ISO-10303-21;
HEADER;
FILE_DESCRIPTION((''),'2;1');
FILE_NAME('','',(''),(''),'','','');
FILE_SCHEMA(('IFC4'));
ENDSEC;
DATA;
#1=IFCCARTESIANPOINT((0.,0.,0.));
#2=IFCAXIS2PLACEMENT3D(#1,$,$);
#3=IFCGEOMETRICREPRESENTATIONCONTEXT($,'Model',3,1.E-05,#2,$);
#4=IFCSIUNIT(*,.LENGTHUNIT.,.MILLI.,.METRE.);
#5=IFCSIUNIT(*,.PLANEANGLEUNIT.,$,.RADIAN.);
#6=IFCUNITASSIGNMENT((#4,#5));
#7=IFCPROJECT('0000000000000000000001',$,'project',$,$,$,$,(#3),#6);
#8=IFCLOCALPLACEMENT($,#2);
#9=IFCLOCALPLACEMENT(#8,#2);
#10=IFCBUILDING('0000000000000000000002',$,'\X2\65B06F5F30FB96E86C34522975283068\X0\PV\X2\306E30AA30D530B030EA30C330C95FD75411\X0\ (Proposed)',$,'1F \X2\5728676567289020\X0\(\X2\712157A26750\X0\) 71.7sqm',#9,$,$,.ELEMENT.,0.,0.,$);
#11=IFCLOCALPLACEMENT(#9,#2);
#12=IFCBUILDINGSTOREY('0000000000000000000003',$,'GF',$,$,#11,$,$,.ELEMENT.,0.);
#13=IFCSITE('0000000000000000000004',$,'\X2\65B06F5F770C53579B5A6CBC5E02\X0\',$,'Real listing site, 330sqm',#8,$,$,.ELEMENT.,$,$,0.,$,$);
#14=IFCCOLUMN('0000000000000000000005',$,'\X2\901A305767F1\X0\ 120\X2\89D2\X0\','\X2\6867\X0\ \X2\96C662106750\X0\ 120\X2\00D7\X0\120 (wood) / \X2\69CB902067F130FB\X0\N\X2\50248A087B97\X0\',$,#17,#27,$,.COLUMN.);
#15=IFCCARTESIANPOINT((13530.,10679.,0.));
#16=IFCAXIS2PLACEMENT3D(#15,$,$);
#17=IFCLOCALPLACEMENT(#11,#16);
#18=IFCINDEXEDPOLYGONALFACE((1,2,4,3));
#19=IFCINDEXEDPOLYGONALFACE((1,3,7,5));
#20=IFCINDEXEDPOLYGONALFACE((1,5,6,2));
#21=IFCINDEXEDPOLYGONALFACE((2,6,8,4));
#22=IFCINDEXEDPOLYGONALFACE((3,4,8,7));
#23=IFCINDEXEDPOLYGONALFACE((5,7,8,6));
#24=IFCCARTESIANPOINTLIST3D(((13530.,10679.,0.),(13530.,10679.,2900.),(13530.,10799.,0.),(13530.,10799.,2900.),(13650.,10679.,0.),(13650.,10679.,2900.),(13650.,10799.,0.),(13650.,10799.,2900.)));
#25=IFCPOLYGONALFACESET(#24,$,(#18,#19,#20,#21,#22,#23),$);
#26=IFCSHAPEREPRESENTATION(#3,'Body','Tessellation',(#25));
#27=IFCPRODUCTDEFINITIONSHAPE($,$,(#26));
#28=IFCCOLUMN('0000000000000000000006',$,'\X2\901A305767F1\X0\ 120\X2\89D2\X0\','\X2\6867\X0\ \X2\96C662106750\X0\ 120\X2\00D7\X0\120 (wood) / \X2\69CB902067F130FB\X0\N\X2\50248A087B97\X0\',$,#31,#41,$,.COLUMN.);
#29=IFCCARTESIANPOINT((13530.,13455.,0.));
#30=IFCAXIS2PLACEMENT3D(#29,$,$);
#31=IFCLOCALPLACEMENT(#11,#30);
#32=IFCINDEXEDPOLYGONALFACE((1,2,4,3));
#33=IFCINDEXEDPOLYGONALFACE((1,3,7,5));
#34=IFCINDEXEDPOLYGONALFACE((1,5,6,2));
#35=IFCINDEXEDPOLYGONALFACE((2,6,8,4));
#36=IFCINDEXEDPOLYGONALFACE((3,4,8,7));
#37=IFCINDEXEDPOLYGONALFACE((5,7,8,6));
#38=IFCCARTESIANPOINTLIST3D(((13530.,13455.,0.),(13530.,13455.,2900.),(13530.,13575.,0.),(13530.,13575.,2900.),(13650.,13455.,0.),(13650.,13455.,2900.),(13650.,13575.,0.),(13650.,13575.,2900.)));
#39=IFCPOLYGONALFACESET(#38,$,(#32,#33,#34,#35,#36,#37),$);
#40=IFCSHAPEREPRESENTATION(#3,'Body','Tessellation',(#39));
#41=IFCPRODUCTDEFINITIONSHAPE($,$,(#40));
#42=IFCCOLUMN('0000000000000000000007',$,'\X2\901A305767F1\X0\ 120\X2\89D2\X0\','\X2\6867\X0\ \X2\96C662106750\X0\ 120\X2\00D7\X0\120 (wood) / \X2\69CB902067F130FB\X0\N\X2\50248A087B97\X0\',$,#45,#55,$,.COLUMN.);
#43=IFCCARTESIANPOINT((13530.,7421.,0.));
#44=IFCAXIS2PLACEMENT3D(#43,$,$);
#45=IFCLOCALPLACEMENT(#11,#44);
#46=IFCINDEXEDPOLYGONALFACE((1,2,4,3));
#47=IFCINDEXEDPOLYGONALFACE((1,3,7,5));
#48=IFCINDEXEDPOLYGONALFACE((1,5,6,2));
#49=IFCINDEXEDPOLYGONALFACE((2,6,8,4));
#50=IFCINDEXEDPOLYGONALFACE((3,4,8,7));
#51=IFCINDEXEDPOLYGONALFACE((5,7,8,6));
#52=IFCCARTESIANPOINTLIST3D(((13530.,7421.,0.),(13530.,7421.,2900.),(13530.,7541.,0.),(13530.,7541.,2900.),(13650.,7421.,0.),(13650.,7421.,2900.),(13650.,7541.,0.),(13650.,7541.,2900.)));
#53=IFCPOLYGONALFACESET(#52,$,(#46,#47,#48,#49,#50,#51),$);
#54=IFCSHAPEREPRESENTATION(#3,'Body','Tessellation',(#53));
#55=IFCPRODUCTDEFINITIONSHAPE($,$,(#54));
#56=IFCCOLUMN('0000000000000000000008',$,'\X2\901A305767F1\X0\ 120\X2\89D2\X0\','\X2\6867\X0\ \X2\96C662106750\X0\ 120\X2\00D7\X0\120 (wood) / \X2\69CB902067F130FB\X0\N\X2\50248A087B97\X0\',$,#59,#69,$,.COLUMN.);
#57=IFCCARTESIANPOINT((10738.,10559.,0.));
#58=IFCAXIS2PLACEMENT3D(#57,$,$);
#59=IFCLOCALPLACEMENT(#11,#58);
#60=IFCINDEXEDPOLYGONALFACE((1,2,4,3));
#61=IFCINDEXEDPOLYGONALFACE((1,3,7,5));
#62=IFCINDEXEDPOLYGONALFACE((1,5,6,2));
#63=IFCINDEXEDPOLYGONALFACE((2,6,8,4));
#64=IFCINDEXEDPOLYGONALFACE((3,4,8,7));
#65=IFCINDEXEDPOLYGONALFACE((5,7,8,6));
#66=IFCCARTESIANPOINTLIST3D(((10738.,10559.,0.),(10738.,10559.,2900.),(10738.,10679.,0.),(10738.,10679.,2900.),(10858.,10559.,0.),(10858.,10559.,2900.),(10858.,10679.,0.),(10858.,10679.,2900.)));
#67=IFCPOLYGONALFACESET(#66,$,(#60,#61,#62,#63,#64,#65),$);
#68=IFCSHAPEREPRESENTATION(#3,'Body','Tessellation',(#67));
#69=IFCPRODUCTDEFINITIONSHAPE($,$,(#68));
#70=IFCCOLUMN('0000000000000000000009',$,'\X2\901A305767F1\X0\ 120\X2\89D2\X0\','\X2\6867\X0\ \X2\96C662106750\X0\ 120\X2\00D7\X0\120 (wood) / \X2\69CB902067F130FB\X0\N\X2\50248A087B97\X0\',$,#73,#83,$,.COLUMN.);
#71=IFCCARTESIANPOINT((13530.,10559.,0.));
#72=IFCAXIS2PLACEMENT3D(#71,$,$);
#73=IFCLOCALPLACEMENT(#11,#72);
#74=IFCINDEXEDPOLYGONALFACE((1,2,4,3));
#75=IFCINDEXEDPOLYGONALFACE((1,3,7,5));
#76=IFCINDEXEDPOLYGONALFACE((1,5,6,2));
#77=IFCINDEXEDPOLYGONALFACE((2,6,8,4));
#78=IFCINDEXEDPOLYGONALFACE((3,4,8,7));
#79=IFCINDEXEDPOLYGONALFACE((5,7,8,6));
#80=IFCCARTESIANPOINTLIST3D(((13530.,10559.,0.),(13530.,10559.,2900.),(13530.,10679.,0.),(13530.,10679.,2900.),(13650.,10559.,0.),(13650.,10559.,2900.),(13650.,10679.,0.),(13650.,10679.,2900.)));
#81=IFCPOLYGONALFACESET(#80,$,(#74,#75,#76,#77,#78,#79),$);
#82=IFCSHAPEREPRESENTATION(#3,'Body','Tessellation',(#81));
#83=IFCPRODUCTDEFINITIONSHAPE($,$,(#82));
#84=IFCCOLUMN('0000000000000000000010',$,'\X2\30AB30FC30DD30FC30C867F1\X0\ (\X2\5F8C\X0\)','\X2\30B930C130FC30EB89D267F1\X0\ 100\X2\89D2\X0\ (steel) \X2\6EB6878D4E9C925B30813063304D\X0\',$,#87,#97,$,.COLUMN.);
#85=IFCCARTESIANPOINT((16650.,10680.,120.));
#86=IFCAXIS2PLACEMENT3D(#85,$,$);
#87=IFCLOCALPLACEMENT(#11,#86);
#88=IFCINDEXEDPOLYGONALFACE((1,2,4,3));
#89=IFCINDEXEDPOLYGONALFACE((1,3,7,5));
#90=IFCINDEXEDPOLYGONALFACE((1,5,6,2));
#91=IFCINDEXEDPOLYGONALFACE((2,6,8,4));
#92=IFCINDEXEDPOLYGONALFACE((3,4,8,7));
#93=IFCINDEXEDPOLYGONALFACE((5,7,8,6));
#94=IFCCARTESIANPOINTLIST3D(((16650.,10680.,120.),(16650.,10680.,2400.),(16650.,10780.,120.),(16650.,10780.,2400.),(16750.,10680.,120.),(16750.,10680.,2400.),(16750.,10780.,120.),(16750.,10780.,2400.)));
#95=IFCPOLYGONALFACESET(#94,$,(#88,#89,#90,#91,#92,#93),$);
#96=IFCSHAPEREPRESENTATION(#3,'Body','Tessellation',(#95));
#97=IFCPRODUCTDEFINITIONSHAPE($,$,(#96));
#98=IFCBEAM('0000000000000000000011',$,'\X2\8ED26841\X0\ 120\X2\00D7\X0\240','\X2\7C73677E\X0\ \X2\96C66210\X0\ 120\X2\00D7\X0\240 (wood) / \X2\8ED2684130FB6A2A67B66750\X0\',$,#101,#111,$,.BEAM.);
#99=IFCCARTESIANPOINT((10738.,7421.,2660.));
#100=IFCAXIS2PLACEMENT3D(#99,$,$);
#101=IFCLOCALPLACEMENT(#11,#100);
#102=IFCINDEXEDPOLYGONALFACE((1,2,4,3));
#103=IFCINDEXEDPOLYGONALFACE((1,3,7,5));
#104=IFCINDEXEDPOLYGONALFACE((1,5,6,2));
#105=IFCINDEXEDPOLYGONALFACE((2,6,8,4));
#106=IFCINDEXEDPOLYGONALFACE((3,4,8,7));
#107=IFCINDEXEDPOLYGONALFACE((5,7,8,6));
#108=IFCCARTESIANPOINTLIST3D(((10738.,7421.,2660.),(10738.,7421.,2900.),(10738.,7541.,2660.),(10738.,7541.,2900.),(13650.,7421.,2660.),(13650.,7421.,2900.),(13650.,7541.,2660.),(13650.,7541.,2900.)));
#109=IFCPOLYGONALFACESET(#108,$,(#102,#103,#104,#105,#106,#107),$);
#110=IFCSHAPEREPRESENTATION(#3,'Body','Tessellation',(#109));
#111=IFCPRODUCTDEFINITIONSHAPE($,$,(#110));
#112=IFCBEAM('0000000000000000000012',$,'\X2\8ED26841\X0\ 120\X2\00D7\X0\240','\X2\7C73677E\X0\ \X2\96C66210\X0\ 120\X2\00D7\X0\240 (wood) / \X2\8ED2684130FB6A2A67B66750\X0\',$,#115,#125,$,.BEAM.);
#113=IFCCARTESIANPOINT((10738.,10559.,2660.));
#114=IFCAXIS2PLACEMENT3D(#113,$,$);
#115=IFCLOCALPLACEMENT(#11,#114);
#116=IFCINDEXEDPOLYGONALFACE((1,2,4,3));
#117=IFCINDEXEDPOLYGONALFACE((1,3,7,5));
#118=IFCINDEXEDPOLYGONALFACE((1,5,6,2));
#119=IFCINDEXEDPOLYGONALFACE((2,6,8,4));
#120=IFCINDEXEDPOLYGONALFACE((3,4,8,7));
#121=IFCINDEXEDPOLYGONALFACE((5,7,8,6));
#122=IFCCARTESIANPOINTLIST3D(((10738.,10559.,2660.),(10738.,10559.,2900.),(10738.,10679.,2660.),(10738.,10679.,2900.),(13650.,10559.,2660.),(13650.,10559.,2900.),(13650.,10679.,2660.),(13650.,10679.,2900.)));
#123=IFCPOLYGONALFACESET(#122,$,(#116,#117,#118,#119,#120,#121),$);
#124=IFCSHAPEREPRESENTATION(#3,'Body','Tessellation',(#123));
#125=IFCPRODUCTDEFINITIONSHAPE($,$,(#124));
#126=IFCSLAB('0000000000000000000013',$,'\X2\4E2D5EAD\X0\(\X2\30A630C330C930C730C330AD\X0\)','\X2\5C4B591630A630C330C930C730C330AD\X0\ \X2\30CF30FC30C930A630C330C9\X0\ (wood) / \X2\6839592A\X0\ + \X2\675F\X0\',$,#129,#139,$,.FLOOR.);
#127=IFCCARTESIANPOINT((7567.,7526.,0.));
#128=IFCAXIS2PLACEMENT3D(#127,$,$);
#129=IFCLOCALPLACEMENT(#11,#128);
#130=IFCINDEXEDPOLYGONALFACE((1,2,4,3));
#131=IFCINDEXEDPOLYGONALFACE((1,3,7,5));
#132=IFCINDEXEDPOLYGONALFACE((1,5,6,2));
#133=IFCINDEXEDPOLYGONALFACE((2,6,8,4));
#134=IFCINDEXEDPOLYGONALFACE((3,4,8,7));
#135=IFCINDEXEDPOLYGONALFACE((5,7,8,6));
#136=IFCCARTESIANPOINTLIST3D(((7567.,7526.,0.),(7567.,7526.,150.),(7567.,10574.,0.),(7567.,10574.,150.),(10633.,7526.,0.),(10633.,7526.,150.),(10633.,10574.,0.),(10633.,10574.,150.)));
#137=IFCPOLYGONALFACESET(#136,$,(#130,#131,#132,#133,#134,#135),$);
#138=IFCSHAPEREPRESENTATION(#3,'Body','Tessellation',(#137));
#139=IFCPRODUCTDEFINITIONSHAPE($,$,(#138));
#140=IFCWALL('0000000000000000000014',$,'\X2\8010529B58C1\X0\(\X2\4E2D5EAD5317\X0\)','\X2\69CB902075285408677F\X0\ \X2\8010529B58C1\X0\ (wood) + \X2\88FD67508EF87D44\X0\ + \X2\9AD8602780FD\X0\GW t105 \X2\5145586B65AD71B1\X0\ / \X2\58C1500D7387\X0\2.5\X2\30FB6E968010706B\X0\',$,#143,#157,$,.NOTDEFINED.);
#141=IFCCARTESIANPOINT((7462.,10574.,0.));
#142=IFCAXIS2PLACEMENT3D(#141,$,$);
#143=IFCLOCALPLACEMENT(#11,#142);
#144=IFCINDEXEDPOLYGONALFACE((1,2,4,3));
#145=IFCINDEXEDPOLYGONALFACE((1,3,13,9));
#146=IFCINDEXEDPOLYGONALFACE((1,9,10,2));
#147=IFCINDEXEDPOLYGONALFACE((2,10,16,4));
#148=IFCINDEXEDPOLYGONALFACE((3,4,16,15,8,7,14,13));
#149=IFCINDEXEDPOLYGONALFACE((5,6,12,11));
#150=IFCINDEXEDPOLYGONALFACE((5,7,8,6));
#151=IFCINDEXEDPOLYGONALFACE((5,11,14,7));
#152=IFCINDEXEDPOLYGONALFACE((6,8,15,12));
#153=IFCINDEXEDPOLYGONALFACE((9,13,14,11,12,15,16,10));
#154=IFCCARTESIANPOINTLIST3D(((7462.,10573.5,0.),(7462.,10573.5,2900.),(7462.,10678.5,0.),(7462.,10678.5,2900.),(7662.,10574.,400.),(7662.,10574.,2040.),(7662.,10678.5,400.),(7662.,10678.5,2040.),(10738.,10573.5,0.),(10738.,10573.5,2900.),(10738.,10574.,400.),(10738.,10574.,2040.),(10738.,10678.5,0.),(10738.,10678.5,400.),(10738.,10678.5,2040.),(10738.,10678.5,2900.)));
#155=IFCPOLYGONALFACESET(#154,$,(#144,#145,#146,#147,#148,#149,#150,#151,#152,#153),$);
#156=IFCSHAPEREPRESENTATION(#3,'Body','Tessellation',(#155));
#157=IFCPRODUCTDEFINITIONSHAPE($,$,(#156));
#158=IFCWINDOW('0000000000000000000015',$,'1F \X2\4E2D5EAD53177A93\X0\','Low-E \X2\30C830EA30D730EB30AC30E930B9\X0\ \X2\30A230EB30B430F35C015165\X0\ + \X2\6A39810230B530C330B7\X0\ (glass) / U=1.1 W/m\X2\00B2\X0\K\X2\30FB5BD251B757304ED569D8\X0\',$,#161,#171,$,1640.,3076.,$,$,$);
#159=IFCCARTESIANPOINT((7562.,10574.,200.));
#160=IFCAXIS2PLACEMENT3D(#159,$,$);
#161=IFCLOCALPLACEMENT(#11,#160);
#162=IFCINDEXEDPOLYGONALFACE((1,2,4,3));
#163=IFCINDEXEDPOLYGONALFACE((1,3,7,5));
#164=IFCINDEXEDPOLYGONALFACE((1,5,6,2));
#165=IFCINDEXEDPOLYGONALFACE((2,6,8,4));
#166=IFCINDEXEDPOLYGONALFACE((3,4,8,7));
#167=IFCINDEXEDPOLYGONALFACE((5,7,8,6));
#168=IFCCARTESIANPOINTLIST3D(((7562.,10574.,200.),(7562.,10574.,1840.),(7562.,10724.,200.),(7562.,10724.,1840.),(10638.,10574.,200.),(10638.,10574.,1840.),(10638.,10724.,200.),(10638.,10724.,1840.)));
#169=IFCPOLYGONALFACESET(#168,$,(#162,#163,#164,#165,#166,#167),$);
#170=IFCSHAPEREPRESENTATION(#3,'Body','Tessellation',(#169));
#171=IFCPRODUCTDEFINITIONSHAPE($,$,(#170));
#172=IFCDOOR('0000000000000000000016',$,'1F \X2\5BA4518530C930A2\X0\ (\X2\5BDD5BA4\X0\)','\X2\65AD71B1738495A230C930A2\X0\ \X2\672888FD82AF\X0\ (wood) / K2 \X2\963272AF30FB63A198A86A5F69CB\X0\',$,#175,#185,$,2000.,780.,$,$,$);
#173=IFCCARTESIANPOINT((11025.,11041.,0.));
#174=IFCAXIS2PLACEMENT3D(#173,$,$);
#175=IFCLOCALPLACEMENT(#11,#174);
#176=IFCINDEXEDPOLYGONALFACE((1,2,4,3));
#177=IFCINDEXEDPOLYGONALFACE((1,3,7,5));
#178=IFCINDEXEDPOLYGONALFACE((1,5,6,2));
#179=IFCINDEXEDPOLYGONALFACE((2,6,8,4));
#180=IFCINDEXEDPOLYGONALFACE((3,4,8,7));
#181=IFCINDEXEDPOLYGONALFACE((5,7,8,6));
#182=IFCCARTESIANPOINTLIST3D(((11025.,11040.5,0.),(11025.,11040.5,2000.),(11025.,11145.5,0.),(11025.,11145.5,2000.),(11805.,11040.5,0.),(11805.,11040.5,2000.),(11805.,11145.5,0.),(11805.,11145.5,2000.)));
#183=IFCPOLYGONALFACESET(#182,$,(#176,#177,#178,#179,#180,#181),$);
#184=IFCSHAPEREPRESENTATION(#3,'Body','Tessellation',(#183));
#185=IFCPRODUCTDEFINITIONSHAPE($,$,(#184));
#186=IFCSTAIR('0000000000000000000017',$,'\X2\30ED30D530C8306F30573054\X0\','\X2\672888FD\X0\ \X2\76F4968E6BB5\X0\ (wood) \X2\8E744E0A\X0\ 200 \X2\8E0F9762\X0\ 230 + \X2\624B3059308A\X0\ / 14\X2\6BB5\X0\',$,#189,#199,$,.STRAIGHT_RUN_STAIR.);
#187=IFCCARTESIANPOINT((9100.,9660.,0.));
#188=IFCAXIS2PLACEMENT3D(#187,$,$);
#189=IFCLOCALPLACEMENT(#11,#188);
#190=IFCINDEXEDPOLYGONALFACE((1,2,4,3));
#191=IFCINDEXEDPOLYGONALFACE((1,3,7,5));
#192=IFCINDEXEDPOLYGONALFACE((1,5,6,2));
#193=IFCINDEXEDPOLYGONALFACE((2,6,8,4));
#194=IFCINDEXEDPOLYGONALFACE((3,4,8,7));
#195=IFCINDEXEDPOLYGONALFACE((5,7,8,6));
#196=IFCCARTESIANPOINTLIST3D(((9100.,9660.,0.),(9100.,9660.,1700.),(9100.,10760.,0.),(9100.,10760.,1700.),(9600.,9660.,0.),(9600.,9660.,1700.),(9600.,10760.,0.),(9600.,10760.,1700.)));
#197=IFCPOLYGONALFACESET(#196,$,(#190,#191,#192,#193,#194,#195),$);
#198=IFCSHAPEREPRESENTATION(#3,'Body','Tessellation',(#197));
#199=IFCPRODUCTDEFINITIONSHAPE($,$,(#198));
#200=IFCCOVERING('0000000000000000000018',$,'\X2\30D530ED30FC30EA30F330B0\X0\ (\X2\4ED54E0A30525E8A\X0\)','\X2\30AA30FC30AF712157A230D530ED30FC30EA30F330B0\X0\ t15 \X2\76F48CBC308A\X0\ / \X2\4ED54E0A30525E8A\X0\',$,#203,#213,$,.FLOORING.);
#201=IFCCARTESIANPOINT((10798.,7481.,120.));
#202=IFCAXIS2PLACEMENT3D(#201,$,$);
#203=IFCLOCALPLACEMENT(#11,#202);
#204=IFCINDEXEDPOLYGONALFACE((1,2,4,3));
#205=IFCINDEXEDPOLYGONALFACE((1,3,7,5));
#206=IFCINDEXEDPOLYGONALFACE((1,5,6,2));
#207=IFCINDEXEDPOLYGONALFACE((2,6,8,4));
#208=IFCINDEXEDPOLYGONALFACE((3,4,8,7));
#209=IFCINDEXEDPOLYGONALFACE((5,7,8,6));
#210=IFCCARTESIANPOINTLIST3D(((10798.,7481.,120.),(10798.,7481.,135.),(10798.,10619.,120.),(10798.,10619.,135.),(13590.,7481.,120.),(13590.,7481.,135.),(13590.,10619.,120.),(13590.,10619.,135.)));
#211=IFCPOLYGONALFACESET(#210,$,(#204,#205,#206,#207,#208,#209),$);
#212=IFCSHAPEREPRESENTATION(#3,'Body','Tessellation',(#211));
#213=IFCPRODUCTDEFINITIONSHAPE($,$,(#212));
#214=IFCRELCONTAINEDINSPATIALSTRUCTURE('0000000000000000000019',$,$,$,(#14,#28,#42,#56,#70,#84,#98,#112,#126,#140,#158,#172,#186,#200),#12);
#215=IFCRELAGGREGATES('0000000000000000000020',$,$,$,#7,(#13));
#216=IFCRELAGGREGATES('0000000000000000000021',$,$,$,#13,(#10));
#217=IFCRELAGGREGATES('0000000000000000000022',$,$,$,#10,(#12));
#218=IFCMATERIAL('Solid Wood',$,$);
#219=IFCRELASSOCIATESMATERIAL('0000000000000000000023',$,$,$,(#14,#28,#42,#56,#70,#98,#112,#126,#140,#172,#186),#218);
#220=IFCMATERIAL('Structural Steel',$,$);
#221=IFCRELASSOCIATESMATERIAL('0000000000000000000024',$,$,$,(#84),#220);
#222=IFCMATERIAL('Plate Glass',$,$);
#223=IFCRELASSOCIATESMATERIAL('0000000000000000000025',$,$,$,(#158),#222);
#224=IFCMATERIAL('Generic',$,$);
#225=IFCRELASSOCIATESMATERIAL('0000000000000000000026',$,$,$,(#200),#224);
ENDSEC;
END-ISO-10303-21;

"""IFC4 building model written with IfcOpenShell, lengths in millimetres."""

from ifc_helpers import new_model, si_unit, frame, frame_2d, origin, place, context, project, spatial, rectangle, extrude, material, element, fill, save


model = new_model("IFC4")

# Units and contexts
model_context = context("Model", 3, precision=1e-05, world=origin())
ifc_project = project(units=[si_unit("LENGTHUNIT", "METRE", prefix="MILLI"), si_unit("PLANEANGLEUNIT", "RADIAN")], contexts=[model_context])

# Site, building, storey
site_placement = place(None, origin())
site = spatial("IfcSite", under=ifc_project, at=site_placement, Name="新潟県南魚沼市", ObjectType="Real listing site, 330sqm", CompositionType="ELEMENT", RefElevation=0.0)
building_placement = place(site_placement, origin())
building = spatial("IfcBuilding", under=site, at=building_placement, Name="新潟・雨水利用とPVのオフグリッド志向 (Proposed)", ObjectType="1F 在来木造(無垢材) 71.7sqm", CompositionType="ELEMENT", ElevationOfRefHeight=0.0, ElevationOfTerrain=0.0)
storey_placement = place(building_placement, origin())
storey = spatial("IfcBuildingStorey", under=building, at=storey_placement, Name="GF", CompositionType="ELEMENT", Elevation=0.0)

# Columns
ifc_material_1 = material(Name="Solid Wood")
column_1_placement = place(storey_placement, frame((13530.0, 10679.0, 0.0)))
element("IfcColumn", 1, at=column_1_placement, inside=storey, material=ifc_material_1, Name="通し柱 120角", Description="桧 集成材 120×120 (wood) / 構造柱・N値計算", PredefinedType="COLUMN", context=model_context, shape_type="SweptSolid", body=[
    extrude(rectangle(XDim=120.0, YDim=120.0, at=frame_2d((60.0, 60.0))), frame((13530.0, 10679.0, 0.0)), (0.0, 0.0, 1.0), 2900.0),
])
column_2_placement = place(storey_placement, frame((13530.0, 13455.0, 0.0)))
element("IfcColumn", 2, at=column_2_placement, inside=storey, material=ifc_material_1, Name="通し柱 120角", Description="桧 集成材 120×120 (wood) / 構造柱・N値計算", PredefinedType="COLUMN", context=model_context, shape_type="SweptSolid", body=[
    extrude(rectangle(XDim=120.0, YDim=120.0, at=frame_2d((60.0, 60.0))), frame((13530.0, 13455.0, 0.0)), (0.0, 0.0, 1.0), 2900.0),
])
column_3_placement = place(storey_placement, frame((13530.0, 7421.0, 0.0)))
element("IfcColumn", 3, at=column_3_placement, inside=storey, material=ifc_material_1, Name="通し柱 120角", Description="桧 集成材 120×120 (wood) / 構造柱・N値計算", PredefinedType="COLUMN", context=model_context, shape_type="SweptSolid", body=[
    extrude(rectangle(XDim=120.0, YDim=120.0, at=frame_2d((60.0, 60.0))), frame((13530.0, 7421.0, 0.0)), (0.0, 0.0, 1.0), 2900.0),
])
column_4_placement = place(storey_placement, frame((10738.0, 10559.0, 0.0)))
element("IfcColumn", 4, at=column_4_placement, inside=storey, material=ifc_material_1, Name="通し柱 120角", Description="桧 集成材 120×120 (wood) / 構造柱・N値計算", PredefinedType="COLUMN", context=model_context, shape_type="SweptSolid", body=[
    extrude(rectangle(XDim=120.0, YDim=120.0, at=frame_2d((60.0, 60.0))), frame((10738.0, 10559.0, 0.0)), (0.0, 0.0, 1.0), 2900.0),
])
column_5_placement = place(storey_placement, frame((13530.0, 10559.0, 0.0)))
element("IfcColumn", 5, at=column_5_placement, inside=storey, material=ifc_material_1, Name="通し柱 120角", Description="桧 集成材 120×120 (wood) / 構造柱・N値計算", PredefinedType="COLUMN", context=model_context, shape_type="SweptSolid", body=[
    extrude(rectangle(XDim=120.0, YDim=120.0, at=frame_2d((60.0, 60.0))), frame((13530.0, 10559.0, 0.0)), (0.0, 0.0, 1.0), 2900.0),
])
ifc_material_2 = material(Name="Structural Steel")
column_6_placement = place(storey_placement, frame((16650.0, 10680.0, 120.0)))
element("IfcColumn", 6, at=column_6_placement, inside=storey, material=ifc_material_2, Name="カーポート柱 (後)", Description="スチール角柱 100角 (steel) 溶融亜鉛めっき", PredefinedType="COLUMN", context=model_context, shape_type="SweptSolid", body=[
    extrude(rectangle(XDim=100.0, YDim=100.0, at=frame_2d((50.0, 50.0))), frame((16650.0, 10680.0, 120.0)), (0.0, 0.0, 1.0), 2280.0),
])

# Beams
beam_1_placement = place(storey_placement, frame((10738.0, 7421.0, 2660.0)))
element("IfcBeam", 7, at=beam_1_placement, inside=storey, material=ifc_material_1, Name="軒桁 120×240", Description="米松 集成 120×240 (wood) / 軒桁・横架材", PredefinedType="BEAM", context=model_context, shape_type="SweptSolid", body=[
    extrude(rectangle(XDim=2912.0, YDim=120.0, at=frame_2d((1456.0, 60.0))), frame((10738.0, 7421.0, 2660.0)), (0.0, 0.0, 1.0), 240.0),
])
beam_2_placement = place(storey_placement, frame((10738.0, 10559.0, 2660.0)))
element("IfcBeam", 8, at=beam_2_placement, inside=storey, material=ifc_material_1, Name="軒桁 120×240", Description="米松 集成 120×240 (wood) / 軒桁・横架材", PredefinedType="BEAM", context=model_context, shape_type="SweptSolid", body=[
    extrude(rectangle(XDim=2912.0, YDim=120.0, at=frame_2d((1456.0, 60.0))), frame((10738.0, 10559.0, 2660.0)), (0.0, 0.0, 1.0), 240.0),
])

# Slab
slab_placement = place(storey_placement, frame((7567.0, 7526.0, 0.0)))
element("IfcSlab", 9, at=slab_placement, inside=storey, material=ifc_material_1, Name="中庭(ウッドデッキ)", Description="屋外ウッドデッキ ハードウッド (wood) / 根太 + 束", PredefinedType="FLOOR", context=model_context, shape_type="SweptSolid", body=[
    extrude(rectangle(XDim=3066.0, YDim=3048.0, at=frame_2d((1533.0, 1524.0))), frame((7567.0, 7526.0, 0.0)), (0.0, 0.0, 1.0), 150.0),
])

# Wall, opening, window
wall_1_placement = place(storey_placement, frame((7462.0, 10574.0, 0.0)))
wall_1 = element("IfcWall", 10, at=wall_1_placement, inside=storey, material=ifc_material_1, Name="耐力壁(中庭北)", Description="構造用合板 耐力壁 (wood) + 製材軸組 + 高性能GW t105 充填断熱 / 壁倍率2.5・準耐火", PredefinedType="NOTDEFINED", context=model_context, shape_type="SweptSolid", body=[
    extrude(rectangle(XDim=3276.0, YDim=105.0, at=frame_2d((1638.0, 52.0))), frame((7462.0, 10574.0, 0.0)), (0.0, 0.0, 1.0), 2900.0),
])
opening_placement = place(storey_placement, frame((7562.0, 10574.0, 200.0)))
opening = element("IfcOpeningElement", 11, at=opening_placement, cuts=wall_1, PredefinedType="NOTDEFINED", context=model_context, shape_type="SweptSolid", body=[
    extrude(rectangle(XDim=3076.0, YDim=150.0, at=frame_2d((1538.0, 75.0))), frame((7562.0, 10574.0, 200.0)), (0.0, 0.0, 1.0), 1640.0),
])
ifc_material_3 = material(Name="Plate Glass")
window_placement = place(storey_placement, frame((7562.0, 10574.0, 200.0)))
window = element("IfcWindow", 12, at=window_placement, inside=storey, material=ifc_material_3, Name="1F 中庭北窓", Description="Low-E トリプルガラス アルゴン封入 + 樹脂サッシ (glass) / U=1.1 W/m²K・寒冷地仕様", OverallHeight=1640.0, OverallWidth=3076.0, context=model_context, shape_type="SweptSolid", body=[
    extrude(rectangle(XDim=3076.0, YDim=150.0, at=frame_2d((1538.0, 75.0))), frame((7562.0, 10574.0, 200.0)), (0.0, 0.0, 1.0), 1640.0),
])
fill(opening, window)

# Door
door_placement = place(storey_placement, frame((11025.0, 11041.0, 0.0)))
element("IfcDoor", 13, at=door_placement, inside=storey, material=ifc_material_1, Name="1F 室内ドア (寝室)", Description="断熱玄関ドア 木製芯 (wood) / K2 防犯・採風機構", OverallHeight=2000.0, OverallWidth=780.0, context=model_context, shape_type="SweptSolid", body=[
    extrude(rectangle(XDim=780.0, YDim=105.0, at=frame_2d((390.0, 52.0))), frame((11025.0, 11041.0, 0.0)), (0.0, 0.0, 1.0), 2000.0),
])

# Stair
stair_placement = place(storey_placement, frame((9100.0, 9660.0, 0.0)))
element("IfcStair", 14, at=stair_placement, inside=storey, material=ifc_material_1, Name="ロフトはしご", Description="木製 直階段 (wood) 蹴上 200 踏面 230 + 手すり / 14段", PredefinedType="STRAIGHT_RUN_STAIR", context=model_context, shape_type="SweptSolid", body=[
    extrude(rectangle(XDim=500.0, YDim=1100.0, at=frame_2d((250.0, 550.0))), frame((9100.0, 9660.0, 0.0)), (0.0, 0.0, 1.0), 1700.0),
])

# Covering
ifc_material_4 = material(Name="Generic")
covering_placement = place(storey_placement, frame((10798.0, 7481.0, 120.0)))
element("IfcCovering", 15, at=covering_placement, inside=storey, material=ifc_material_4, Name="フローリング (仕上げ床)", Description="オーク無垢フローリング t15 直貼り / 仕上げ床", PredefinedType="FLOORING", context=model_context, shape_type="SweptSolid", body=[
    extrude(rectangle(XDim=2792.0, YDim=3138.0, at=frame_2d((1396.0, 1569.0))), frame((10798.0, 7481.0, 120.0)), (0.0, 0.0, 1.0), 15.0),
])

save(model, "model.ifc")
